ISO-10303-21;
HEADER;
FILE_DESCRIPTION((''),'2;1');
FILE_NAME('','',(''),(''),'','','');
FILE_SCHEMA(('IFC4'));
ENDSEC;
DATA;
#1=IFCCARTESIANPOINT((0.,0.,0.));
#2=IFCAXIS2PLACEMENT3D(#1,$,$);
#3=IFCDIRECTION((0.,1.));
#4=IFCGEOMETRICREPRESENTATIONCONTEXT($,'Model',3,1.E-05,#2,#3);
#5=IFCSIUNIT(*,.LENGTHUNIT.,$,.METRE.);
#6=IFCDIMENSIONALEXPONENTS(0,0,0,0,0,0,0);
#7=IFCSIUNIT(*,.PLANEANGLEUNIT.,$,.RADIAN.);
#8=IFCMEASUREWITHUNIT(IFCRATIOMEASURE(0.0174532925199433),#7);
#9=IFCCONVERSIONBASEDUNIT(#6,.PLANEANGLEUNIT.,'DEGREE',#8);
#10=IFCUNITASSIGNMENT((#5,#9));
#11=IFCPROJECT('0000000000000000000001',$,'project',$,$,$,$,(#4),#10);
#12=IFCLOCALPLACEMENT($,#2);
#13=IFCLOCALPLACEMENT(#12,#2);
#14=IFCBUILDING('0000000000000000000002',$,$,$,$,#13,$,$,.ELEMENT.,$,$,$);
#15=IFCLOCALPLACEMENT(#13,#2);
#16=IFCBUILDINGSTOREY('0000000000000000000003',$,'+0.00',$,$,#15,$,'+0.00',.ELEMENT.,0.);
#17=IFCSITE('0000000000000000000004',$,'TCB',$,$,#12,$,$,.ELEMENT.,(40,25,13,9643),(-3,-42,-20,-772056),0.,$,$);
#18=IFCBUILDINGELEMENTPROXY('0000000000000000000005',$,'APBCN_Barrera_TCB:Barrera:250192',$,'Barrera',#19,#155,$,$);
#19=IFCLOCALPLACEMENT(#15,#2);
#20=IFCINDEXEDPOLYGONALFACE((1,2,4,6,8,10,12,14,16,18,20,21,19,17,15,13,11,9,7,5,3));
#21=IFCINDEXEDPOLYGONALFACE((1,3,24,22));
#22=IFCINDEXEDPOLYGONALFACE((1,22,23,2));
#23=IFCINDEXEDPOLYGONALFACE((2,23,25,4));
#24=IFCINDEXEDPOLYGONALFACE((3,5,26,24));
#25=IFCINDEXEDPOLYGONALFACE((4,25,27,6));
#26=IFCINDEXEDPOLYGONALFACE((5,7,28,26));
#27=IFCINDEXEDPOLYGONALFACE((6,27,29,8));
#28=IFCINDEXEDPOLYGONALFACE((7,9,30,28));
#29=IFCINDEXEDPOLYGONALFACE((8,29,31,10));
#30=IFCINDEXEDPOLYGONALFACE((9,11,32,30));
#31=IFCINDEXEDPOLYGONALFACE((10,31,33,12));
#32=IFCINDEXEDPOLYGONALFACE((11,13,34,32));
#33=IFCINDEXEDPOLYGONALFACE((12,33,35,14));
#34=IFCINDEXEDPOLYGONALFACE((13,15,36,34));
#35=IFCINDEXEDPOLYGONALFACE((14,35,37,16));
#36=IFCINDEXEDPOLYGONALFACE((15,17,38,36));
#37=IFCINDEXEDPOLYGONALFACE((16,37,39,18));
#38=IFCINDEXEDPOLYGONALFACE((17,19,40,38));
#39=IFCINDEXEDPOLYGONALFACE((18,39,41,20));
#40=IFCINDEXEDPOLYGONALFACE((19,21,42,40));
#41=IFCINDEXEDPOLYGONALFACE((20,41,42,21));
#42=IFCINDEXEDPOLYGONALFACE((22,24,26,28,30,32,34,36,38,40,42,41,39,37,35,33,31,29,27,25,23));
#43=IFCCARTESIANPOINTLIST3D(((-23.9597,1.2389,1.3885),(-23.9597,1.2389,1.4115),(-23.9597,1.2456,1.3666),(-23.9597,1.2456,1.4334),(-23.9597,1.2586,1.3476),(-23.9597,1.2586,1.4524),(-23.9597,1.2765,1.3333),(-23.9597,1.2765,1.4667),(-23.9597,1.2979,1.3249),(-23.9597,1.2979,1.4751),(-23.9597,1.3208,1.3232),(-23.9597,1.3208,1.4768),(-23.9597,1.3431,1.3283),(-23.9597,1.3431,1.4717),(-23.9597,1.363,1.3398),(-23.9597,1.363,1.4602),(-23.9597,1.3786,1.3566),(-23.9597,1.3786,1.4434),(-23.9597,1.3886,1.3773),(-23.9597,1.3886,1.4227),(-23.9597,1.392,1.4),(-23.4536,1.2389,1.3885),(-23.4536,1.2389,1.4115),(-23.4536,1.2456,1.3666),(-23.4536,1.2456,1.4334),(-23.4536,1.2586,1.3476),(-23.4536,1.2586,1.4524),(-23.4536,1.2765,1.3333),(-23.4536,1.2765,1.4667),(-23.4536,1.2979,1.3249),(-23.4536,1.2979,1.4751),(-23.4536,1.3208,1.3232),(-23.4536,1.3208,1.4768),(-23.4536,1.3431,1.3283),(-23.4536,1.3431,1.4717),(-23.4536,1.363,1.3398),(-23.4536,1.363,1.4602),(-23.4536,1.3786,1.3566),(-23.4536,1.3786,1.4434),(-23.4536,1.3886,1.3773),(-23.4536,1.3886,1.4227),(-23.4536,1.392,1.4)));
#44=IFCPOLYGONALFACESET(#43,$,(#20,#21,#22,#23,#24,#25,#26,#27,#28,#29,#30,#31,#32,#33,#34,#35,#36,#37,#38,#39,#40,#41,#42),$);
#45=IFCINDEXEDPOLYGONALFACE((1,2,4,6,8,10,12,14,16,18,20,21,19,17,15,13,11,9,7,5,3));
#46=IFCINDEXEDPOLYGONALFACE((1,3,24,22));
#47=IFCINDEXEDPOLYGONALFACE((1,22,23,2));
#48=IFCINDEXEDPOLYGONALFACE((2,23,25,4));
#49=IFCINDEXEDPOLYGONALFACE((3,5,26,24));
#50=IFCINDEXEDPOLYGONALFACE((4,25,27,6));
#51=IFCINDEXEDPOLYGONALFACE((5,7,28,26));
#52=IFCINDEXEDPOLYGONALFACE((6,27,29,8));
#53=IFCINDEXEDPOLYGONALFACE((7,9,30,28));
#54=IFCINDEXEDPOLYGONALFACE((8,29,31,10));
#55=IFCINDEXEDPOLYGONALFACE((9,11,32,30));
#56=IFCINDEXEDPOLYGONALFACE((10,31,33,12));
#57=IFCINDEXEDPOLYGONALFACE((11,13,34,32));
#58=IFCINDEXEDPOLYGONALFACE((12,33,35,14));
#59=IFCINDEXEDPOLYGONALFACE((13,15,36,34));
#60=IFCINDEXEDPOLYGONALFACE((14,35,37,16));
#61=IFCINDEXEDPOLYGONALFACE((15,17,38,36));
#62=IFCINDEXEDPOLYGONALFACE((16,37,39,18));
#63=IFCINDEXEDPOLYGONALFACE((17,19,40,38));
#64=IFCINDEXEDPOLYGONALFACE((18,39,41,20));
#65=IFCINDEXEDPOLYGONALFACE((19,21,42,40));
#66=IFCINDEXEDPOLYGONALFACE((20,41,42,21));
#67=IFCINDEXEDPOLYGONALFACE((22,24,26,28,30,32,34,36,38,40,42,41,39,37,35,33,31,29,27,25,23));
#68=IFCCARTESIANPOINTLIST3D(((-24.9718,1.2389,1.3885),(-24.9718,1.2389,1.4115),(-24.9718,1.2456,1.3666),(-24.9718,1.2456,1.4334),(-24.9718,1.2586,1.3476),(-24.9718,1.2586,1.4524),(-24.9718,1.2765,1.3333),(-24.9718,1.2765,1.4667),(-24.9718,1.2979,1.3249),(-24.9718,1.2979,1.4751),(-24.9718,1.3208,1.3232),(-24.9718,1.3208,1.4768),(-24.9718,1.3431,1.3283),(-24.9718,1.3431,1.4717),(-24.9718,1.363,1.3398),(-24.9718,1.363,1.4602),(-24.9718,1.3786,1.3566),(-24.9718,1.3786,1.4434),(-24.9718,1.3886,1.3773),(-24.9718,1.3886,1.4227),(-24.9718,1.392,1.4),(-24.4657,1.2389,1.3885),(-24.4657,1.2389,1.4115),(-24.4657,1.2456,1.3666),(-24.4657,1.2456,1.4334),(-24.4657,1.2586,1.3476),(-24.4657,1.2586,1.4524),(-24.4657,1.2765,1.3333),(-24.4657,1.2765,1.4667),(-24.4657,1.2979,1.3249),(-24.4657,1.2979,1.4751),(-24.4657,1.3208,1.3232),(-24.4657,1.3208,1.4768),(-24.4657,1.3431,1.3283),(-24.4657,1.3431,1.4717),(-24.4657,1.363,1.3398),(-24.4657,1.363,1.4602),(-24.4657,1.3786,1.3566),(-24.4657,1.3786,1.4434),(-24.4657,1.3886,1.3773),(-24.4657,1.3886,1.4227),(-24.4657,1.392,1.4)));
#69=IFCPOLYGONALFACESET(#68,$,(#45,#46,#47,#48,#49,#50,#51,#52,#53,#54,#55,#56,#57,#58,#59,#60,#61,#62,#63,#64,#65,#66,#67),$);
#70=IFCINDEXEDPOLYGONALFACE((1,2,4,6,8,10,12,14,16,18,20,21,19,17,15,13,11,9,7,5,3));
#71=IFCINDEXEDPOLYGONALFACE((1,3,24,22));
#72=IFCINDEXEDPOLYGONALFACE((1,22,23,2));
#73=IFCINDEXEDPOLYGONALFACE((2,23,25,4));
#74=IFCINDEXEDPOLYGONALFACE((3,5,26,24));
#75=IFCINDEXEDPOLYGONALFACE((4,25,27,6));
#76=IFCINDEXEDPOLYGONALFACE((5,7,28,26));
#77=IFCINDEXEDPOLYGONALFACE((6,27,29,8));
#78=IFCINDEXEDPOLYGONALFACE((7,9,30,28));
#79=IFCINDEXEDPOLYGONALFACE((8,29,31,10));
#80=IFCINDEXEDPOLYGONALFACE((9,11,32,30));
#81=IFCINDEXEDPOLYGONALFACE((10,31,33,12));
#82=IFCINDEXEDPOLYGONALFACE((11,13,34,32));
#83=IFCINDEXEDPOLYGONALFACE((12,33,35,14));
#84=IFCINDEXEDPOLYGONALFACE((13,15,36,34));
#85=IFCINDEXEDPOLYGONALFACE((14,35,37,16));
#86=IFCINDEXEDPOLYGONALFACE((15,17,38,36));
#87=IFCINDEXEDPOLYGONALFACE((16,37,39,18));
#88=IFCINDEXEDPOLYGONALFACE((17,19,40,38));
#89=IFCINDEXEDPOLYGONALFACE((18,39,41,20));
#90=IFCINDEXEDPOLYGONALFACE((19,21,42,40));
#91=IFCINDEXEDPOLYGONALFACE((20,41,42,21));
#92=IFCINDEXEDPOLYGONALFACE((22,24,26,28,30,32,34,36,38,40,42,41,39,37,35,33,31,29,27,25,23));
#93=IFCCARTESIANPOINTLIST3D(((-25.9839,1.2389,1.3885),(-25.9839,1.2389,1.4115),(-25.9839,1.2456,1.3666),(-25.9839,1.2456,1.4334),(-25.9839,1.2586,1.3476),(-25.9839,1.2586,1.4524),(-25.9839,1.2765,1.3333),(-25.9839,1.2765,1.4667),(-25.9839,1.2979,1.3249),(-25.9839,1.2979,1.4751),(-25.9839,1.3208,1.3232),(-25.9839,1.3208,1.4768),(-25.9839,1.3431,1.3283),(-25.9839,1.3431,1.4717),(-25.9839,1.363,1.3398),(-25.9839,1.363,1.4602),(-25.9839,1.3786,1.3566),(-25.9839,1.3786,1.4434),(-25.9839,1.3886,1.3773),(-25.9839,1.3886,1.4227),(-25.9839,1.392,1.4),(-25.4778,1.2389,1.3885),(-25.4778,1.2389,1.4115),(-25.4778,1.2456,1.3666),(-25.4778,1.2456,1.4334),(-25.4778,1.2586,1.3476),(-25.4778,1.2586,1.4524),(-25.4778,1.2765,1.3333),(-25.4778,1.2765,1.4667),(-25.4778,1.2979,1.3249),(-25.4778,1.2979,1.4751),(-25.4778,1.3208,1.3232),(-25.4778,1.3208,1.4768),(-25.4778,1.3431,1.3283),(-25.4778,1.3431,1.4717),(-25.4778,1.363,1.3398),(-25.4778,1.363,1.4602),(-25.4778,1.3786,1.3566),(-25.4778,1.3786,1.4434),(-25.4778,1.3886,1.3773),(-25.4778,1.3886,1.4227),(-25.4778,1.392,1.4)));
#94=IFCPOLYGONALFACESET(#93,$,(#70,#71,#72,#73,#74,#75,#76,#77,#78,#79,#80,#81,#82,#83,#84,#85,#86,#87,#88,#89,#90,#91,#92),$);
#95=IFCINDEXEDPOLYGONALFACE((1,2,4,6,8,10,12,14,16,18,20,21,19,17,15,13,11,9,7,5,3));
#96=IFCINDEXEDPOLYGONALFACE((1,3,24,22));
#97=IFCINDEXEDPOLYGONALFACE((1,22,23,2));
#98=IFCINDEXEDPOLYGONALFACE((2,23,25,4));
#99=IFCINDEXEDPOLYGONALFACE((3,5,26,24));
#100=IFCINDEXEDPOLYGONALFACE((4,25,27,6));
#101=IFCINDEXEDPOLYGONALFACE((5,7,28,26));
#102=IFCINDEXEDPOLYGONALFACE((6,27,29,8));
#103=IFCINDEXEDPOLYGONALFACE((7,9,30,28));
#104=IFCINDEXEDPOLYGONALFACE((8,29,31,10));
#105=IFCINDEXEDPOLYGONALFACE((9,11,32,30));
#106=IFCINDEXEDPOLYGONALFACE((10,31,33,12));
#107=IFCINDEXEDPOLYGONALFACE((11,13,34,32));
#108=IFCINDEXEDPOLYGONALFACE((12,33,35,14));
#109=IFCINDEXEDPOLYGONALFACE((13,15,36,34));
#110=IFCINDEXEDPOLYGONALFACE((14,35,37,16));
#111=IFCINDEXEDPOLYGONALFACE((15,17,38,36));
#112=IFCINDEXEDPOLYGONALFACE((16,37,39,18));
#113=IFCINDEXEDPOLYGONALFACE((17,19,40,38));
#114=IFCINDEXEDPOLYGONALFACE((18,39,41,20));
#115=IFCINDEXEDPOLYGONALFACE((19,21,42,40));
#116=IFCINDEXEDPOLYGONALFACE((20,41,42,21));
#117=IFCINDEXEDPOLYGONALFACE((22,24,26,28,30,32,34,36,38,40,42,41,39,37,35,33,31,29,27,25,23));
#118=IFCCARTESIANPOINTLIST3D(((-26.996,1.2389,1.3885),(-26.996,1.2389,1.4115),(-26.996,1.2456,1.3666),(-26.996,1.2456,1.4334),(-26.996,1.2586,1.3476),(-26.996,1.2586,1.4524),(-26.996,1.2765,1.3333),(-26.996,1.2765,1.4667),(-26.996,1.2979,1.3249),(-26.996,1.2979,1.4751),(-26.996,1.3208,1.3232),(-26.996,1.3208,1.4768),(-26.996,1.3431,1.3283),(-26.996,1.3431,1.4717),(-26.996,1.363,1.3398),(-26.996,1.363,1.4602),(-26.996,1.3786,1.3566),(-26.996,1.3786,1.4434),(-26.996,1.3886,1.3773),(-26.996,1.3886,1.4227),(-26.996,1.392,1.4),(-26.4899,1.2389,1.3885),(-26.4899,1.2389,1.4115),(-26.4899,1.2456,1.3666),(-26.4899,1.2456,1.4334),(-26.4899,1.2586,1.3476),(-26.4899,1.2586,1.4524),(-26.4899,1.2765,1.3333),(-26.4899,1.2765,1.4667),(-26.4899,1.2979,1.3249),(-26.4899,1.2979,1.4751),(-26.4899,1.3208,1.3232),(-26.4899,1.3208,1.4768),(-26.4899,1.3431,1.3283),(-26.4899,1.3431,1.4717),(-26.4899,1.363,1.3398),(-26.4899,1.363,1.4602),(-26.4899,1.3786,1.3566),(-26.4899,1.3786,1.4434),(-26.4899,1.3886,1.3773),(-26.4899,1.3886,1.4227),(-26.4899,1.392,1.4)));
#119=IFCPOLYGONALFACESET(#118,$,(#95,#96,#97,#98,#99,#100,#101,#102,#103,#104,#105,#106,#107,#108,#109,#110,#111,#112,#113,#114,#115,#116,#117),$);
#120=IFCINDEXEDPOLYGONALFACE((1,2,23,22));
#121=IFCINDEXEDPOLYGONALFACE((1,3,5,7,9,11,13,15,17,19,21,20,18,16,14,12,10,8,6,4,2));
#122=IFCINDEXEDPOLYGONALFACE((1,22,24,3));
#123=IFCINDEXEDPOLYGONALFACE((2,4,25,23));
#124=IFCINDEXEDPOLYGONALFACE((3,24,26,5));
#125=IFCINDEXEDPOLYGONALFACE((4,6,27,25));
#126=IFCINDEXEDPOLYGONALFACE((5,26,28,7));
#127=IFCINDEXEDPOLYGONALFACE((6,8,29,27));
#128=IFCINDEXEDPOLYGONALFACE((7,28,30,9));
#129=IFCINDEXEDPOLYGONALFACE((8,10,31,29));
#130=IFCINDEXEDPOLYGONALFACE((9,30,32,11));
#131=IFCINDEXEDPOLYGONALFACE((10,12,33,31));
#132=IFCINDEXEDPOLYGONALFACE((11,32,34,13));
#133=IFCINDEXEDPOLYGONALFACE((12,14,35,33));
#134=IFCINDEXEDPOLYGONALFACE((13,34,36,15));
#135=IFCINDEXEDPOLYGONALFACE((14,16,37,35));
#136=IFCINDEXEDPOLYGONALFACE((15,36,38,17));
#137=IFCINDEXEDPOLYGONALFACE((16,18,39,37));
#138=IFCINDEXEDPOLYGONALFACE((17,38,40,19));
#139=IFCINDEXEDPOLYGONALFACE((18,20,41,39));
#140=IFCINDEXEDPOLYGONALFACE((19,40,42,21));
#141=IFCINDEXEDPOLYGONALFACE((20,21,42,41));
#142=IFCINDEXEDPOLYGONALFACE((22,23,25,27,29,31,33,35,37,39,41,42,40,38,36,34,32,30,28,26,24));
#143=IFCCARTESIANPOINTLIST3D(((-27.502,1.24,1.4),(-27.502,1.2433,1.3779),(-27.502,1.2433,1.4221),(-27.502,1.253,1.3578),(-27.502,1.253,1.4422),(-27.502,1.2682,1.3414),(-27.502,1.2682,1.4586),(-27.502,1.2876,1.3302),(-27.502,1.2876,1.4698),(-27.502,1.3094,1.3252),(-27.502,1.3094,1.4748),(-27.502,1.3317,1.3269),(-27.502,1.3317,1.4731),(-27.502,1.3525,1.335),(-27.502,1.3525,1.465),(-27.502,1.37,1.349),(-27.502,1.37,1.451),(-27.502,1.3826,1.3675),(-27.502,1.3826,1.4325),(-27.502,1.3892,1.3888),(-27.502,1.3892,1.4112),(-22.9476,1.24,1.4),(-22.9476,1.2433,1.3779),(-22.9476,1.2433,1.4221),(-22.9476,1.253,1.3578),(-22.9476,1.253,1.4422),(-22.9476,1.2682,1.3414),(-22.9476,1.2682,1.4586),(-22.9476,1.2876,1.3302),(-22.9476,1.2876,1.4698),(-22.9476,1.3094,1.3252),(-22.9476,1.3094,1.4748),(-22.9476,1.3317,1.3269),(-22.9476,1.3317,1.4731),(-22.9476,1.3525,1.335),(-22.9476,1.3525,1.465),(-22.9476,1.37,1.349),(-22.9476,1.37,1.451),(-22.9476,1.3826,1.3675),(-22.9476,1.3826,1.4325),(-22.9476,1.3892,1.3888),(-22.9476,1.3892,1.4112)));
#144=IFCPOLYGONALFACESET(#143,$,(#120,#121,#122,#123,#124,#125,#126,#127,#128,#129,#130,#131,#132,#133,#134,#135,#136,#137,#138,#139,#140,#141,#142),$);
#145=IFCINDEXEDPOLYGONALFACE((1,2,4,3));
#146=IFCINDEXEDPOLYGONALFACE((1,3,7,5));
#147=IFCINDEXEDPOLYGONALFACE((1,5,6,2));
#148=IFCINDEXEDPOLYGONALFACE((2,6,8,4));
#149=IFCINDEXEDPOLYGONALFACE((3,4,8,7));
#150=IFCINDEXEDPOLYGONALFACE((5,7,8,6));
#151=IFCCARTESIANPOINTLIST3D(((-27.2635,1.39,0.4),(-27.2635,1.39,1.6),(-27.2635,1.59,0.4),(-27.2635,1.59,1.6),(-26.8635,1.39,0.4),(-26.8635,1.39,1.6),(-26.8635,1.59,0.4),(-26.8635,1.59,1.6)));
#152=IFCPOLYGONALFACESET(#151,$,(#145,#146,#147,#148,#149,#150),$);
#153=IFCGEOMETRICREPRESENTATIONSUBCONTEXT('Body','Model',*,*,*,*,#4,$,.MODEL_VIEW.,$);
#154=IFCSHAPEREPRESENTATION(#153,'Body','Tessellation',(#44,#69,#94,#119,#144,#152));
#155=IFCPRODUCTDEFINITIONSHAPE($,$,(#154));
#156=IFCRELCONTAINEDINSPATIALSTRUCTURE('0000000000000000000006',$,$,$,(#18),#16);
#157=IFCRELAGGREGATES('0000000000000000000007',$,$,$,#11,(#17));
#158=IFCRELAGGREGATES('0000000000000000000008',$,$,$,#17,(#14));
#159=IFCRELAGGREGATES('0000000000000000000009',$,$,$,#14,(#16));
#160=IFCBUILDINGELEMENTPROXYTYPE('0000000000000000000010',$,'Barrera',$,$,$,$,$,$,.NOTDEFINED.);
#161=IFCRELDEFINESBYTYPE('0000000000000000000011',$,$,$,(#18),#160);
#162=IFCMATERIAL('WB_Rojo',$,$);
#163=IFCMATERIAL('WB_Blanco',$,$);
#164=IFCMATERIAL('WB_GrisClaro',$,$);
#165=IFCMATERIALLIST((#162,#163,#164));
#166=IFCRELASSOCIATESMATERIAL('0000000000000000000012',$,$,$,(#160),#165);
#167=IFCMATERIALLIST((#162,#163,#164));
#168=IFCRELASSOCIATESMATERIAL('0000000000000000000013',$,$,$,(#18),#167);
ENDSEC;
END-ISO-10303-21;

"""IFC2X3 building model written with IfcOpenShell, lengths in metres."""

from ifc_helpers import new_model, entity, si_unit, converted_unit, direction, frame, frame_2d, origin, place, context, subcontext, project, spatial, rectangle, circle, extrude, source, transform, mapped, material, material_list, type_object, type_shapes, element, save


model = new_model("IFC2X3")

# Units and contexts
model_context = context("Model", 3, precision=1e-05, world=origin(), true_north=direction((0.0, 1.0)))
body_context = subcontext(model_context, "Body", "Model", "MODEL_VIEW")
ifc_project = project(units=[si_unit("LENGTHUNIT", "METRE"), converted_unit("PLANEANGLEUNIT", "DEGREE", entity("IfcRatioMeasure", 0.0174532925199433), si_unit("PLANEANGLEUNIT", "RADIAN"), dimensions=[0, 0, 0, 0, 0, 0, 0])], contexts=[model_context])

# Site, building, storey
site_placement = place(None, origin())
site = spatial("IfcSite", under=ifc_project, at=site_placement, Name="TCB", CompositionType="ELEMENT", RefLatitude=(40, 25, 13, 9643), RefLongitude=(-3, -42, -20, -772056), RefElevation=0.0)
building_placement = place(site_placement, origin())
building = spatial("IfcBuilding", under=site, at=building_placement, CompositionType="ELEMENT")
storey_placement = place(building_placement, origin())
storey = spatial("IfcBuildingStorey", under=building, at=storey_placement, Name="+0.00", LongName="+0.00", CompositionType="ELEMENT", Elevation=0.0)

# Shared definitions
ifc_material_1 = material(Name="WB_Blanco")

# Building element proxy
ifc_material_2 = material(Name="WB_Rojo")
ifc_material_3 = material(Name="WB_GrisClaro")
ifc_material_list_1 = material_list([ifc_material_2, ifc_material_1, ifc_material_3])
ifc_material_list_2 = material_list([ifc_material_2, ifc_material_1, ifc_material_3])
building_element_proxy_type = type_object("IfcBuildingElementProxyType", Name="Barrera", PredefinedType="NOTDEFINED", material=ifc_material_list_2)
shared_shape_1 = source(origin(), body_context, "Body", "SweptSolid", [
    extrude(circle(Radius=0.077, at=frame_2d((0.0, 0.0), x_axis=(1.0, 0.0))), frame((2.8039, -0.175, 1.0), z_axis=(1.0, 0.0, 0.0), x_axis=(0.0, 1.0, 0.0)), (0.0, 0.0, 1.0), 0.506),
    extrude(circle(Radius=0.077, at=frame_2d((0.0, 0.0), x_axis=(1.0, 0.0))), frame((1.7918, -0.175, 1.0), z_axis=(1.0, 0.0, 0.0), x_axis=(0.0, 1.0, 0.0)), (0.0, 0.0, 1.0), 0.506),
    extrude(circle(Radius=0.077, at=frame_2d((0.0, 0.0), x_axis=(1.0, 0.0))), frame((0.7797, -0.175, 1.0), z_axis=(1.0, 0.0, 0.0), x_axis=(0.0, 1.0, 0.0)), (0.0, 0.0, 1.0), 0.506),
    extrude(circle(Radius=0.077, at=frame_2d((0.0, 0.0), x_axis=(1.0, 0.0))), frame((-0.2324, -0.175, 1.0), z_axis=(1.0, 0.0, 0.0), x_axis=(0.0, 1.0, 0.0)), (0.0, 0.0, 1.0), 0.506),
    extrude(circle(Radius=0.075, at=frame_2d((0.0, 0.0), x_axis=(1.0, 0.0))), frame((-0.7385, -0.175, 1.0), z_axis=(1.0, 0.0, 0.0), x_axis=(0.0, -1.0, 0.0)), (0.0, 0.0, 1.0), 4.5544),
    extrude(rectangle(XDim=0.2, YDim=0.4, at=frame_2d((0.0, 0.0), x_axis=(1.0, 0.0))), frame((-0.3, 0.0, 0.0), z_axis=(0.0, 0.0, 1.0), x_axis=(0.0, -1.0, 0.0)), (0.0, 0.0, 1.0), 1.2),
])
type_shapes(building_element_proxy_type, [shared_shape_1])
proxy_1_placement = place(storey_placement, frame((-26.7635, 1.49, 0.4)))
element("IfcBuildingElementProxy", 1, at=proxy_1_placement, inside=storey, type_object=building_element_proxy_type, material=ifc_material_list_1, Name="APBCN_Barrera_TCB:Barrera:250192", ObjectType="Barrera", context=body_context, shape_type="MappedRepresentation", body=[
    mapped(shared_shape_1, transform((0.0, 0.0, 0.0), scale=1.0)),
])

save(model, "model.ifc")
